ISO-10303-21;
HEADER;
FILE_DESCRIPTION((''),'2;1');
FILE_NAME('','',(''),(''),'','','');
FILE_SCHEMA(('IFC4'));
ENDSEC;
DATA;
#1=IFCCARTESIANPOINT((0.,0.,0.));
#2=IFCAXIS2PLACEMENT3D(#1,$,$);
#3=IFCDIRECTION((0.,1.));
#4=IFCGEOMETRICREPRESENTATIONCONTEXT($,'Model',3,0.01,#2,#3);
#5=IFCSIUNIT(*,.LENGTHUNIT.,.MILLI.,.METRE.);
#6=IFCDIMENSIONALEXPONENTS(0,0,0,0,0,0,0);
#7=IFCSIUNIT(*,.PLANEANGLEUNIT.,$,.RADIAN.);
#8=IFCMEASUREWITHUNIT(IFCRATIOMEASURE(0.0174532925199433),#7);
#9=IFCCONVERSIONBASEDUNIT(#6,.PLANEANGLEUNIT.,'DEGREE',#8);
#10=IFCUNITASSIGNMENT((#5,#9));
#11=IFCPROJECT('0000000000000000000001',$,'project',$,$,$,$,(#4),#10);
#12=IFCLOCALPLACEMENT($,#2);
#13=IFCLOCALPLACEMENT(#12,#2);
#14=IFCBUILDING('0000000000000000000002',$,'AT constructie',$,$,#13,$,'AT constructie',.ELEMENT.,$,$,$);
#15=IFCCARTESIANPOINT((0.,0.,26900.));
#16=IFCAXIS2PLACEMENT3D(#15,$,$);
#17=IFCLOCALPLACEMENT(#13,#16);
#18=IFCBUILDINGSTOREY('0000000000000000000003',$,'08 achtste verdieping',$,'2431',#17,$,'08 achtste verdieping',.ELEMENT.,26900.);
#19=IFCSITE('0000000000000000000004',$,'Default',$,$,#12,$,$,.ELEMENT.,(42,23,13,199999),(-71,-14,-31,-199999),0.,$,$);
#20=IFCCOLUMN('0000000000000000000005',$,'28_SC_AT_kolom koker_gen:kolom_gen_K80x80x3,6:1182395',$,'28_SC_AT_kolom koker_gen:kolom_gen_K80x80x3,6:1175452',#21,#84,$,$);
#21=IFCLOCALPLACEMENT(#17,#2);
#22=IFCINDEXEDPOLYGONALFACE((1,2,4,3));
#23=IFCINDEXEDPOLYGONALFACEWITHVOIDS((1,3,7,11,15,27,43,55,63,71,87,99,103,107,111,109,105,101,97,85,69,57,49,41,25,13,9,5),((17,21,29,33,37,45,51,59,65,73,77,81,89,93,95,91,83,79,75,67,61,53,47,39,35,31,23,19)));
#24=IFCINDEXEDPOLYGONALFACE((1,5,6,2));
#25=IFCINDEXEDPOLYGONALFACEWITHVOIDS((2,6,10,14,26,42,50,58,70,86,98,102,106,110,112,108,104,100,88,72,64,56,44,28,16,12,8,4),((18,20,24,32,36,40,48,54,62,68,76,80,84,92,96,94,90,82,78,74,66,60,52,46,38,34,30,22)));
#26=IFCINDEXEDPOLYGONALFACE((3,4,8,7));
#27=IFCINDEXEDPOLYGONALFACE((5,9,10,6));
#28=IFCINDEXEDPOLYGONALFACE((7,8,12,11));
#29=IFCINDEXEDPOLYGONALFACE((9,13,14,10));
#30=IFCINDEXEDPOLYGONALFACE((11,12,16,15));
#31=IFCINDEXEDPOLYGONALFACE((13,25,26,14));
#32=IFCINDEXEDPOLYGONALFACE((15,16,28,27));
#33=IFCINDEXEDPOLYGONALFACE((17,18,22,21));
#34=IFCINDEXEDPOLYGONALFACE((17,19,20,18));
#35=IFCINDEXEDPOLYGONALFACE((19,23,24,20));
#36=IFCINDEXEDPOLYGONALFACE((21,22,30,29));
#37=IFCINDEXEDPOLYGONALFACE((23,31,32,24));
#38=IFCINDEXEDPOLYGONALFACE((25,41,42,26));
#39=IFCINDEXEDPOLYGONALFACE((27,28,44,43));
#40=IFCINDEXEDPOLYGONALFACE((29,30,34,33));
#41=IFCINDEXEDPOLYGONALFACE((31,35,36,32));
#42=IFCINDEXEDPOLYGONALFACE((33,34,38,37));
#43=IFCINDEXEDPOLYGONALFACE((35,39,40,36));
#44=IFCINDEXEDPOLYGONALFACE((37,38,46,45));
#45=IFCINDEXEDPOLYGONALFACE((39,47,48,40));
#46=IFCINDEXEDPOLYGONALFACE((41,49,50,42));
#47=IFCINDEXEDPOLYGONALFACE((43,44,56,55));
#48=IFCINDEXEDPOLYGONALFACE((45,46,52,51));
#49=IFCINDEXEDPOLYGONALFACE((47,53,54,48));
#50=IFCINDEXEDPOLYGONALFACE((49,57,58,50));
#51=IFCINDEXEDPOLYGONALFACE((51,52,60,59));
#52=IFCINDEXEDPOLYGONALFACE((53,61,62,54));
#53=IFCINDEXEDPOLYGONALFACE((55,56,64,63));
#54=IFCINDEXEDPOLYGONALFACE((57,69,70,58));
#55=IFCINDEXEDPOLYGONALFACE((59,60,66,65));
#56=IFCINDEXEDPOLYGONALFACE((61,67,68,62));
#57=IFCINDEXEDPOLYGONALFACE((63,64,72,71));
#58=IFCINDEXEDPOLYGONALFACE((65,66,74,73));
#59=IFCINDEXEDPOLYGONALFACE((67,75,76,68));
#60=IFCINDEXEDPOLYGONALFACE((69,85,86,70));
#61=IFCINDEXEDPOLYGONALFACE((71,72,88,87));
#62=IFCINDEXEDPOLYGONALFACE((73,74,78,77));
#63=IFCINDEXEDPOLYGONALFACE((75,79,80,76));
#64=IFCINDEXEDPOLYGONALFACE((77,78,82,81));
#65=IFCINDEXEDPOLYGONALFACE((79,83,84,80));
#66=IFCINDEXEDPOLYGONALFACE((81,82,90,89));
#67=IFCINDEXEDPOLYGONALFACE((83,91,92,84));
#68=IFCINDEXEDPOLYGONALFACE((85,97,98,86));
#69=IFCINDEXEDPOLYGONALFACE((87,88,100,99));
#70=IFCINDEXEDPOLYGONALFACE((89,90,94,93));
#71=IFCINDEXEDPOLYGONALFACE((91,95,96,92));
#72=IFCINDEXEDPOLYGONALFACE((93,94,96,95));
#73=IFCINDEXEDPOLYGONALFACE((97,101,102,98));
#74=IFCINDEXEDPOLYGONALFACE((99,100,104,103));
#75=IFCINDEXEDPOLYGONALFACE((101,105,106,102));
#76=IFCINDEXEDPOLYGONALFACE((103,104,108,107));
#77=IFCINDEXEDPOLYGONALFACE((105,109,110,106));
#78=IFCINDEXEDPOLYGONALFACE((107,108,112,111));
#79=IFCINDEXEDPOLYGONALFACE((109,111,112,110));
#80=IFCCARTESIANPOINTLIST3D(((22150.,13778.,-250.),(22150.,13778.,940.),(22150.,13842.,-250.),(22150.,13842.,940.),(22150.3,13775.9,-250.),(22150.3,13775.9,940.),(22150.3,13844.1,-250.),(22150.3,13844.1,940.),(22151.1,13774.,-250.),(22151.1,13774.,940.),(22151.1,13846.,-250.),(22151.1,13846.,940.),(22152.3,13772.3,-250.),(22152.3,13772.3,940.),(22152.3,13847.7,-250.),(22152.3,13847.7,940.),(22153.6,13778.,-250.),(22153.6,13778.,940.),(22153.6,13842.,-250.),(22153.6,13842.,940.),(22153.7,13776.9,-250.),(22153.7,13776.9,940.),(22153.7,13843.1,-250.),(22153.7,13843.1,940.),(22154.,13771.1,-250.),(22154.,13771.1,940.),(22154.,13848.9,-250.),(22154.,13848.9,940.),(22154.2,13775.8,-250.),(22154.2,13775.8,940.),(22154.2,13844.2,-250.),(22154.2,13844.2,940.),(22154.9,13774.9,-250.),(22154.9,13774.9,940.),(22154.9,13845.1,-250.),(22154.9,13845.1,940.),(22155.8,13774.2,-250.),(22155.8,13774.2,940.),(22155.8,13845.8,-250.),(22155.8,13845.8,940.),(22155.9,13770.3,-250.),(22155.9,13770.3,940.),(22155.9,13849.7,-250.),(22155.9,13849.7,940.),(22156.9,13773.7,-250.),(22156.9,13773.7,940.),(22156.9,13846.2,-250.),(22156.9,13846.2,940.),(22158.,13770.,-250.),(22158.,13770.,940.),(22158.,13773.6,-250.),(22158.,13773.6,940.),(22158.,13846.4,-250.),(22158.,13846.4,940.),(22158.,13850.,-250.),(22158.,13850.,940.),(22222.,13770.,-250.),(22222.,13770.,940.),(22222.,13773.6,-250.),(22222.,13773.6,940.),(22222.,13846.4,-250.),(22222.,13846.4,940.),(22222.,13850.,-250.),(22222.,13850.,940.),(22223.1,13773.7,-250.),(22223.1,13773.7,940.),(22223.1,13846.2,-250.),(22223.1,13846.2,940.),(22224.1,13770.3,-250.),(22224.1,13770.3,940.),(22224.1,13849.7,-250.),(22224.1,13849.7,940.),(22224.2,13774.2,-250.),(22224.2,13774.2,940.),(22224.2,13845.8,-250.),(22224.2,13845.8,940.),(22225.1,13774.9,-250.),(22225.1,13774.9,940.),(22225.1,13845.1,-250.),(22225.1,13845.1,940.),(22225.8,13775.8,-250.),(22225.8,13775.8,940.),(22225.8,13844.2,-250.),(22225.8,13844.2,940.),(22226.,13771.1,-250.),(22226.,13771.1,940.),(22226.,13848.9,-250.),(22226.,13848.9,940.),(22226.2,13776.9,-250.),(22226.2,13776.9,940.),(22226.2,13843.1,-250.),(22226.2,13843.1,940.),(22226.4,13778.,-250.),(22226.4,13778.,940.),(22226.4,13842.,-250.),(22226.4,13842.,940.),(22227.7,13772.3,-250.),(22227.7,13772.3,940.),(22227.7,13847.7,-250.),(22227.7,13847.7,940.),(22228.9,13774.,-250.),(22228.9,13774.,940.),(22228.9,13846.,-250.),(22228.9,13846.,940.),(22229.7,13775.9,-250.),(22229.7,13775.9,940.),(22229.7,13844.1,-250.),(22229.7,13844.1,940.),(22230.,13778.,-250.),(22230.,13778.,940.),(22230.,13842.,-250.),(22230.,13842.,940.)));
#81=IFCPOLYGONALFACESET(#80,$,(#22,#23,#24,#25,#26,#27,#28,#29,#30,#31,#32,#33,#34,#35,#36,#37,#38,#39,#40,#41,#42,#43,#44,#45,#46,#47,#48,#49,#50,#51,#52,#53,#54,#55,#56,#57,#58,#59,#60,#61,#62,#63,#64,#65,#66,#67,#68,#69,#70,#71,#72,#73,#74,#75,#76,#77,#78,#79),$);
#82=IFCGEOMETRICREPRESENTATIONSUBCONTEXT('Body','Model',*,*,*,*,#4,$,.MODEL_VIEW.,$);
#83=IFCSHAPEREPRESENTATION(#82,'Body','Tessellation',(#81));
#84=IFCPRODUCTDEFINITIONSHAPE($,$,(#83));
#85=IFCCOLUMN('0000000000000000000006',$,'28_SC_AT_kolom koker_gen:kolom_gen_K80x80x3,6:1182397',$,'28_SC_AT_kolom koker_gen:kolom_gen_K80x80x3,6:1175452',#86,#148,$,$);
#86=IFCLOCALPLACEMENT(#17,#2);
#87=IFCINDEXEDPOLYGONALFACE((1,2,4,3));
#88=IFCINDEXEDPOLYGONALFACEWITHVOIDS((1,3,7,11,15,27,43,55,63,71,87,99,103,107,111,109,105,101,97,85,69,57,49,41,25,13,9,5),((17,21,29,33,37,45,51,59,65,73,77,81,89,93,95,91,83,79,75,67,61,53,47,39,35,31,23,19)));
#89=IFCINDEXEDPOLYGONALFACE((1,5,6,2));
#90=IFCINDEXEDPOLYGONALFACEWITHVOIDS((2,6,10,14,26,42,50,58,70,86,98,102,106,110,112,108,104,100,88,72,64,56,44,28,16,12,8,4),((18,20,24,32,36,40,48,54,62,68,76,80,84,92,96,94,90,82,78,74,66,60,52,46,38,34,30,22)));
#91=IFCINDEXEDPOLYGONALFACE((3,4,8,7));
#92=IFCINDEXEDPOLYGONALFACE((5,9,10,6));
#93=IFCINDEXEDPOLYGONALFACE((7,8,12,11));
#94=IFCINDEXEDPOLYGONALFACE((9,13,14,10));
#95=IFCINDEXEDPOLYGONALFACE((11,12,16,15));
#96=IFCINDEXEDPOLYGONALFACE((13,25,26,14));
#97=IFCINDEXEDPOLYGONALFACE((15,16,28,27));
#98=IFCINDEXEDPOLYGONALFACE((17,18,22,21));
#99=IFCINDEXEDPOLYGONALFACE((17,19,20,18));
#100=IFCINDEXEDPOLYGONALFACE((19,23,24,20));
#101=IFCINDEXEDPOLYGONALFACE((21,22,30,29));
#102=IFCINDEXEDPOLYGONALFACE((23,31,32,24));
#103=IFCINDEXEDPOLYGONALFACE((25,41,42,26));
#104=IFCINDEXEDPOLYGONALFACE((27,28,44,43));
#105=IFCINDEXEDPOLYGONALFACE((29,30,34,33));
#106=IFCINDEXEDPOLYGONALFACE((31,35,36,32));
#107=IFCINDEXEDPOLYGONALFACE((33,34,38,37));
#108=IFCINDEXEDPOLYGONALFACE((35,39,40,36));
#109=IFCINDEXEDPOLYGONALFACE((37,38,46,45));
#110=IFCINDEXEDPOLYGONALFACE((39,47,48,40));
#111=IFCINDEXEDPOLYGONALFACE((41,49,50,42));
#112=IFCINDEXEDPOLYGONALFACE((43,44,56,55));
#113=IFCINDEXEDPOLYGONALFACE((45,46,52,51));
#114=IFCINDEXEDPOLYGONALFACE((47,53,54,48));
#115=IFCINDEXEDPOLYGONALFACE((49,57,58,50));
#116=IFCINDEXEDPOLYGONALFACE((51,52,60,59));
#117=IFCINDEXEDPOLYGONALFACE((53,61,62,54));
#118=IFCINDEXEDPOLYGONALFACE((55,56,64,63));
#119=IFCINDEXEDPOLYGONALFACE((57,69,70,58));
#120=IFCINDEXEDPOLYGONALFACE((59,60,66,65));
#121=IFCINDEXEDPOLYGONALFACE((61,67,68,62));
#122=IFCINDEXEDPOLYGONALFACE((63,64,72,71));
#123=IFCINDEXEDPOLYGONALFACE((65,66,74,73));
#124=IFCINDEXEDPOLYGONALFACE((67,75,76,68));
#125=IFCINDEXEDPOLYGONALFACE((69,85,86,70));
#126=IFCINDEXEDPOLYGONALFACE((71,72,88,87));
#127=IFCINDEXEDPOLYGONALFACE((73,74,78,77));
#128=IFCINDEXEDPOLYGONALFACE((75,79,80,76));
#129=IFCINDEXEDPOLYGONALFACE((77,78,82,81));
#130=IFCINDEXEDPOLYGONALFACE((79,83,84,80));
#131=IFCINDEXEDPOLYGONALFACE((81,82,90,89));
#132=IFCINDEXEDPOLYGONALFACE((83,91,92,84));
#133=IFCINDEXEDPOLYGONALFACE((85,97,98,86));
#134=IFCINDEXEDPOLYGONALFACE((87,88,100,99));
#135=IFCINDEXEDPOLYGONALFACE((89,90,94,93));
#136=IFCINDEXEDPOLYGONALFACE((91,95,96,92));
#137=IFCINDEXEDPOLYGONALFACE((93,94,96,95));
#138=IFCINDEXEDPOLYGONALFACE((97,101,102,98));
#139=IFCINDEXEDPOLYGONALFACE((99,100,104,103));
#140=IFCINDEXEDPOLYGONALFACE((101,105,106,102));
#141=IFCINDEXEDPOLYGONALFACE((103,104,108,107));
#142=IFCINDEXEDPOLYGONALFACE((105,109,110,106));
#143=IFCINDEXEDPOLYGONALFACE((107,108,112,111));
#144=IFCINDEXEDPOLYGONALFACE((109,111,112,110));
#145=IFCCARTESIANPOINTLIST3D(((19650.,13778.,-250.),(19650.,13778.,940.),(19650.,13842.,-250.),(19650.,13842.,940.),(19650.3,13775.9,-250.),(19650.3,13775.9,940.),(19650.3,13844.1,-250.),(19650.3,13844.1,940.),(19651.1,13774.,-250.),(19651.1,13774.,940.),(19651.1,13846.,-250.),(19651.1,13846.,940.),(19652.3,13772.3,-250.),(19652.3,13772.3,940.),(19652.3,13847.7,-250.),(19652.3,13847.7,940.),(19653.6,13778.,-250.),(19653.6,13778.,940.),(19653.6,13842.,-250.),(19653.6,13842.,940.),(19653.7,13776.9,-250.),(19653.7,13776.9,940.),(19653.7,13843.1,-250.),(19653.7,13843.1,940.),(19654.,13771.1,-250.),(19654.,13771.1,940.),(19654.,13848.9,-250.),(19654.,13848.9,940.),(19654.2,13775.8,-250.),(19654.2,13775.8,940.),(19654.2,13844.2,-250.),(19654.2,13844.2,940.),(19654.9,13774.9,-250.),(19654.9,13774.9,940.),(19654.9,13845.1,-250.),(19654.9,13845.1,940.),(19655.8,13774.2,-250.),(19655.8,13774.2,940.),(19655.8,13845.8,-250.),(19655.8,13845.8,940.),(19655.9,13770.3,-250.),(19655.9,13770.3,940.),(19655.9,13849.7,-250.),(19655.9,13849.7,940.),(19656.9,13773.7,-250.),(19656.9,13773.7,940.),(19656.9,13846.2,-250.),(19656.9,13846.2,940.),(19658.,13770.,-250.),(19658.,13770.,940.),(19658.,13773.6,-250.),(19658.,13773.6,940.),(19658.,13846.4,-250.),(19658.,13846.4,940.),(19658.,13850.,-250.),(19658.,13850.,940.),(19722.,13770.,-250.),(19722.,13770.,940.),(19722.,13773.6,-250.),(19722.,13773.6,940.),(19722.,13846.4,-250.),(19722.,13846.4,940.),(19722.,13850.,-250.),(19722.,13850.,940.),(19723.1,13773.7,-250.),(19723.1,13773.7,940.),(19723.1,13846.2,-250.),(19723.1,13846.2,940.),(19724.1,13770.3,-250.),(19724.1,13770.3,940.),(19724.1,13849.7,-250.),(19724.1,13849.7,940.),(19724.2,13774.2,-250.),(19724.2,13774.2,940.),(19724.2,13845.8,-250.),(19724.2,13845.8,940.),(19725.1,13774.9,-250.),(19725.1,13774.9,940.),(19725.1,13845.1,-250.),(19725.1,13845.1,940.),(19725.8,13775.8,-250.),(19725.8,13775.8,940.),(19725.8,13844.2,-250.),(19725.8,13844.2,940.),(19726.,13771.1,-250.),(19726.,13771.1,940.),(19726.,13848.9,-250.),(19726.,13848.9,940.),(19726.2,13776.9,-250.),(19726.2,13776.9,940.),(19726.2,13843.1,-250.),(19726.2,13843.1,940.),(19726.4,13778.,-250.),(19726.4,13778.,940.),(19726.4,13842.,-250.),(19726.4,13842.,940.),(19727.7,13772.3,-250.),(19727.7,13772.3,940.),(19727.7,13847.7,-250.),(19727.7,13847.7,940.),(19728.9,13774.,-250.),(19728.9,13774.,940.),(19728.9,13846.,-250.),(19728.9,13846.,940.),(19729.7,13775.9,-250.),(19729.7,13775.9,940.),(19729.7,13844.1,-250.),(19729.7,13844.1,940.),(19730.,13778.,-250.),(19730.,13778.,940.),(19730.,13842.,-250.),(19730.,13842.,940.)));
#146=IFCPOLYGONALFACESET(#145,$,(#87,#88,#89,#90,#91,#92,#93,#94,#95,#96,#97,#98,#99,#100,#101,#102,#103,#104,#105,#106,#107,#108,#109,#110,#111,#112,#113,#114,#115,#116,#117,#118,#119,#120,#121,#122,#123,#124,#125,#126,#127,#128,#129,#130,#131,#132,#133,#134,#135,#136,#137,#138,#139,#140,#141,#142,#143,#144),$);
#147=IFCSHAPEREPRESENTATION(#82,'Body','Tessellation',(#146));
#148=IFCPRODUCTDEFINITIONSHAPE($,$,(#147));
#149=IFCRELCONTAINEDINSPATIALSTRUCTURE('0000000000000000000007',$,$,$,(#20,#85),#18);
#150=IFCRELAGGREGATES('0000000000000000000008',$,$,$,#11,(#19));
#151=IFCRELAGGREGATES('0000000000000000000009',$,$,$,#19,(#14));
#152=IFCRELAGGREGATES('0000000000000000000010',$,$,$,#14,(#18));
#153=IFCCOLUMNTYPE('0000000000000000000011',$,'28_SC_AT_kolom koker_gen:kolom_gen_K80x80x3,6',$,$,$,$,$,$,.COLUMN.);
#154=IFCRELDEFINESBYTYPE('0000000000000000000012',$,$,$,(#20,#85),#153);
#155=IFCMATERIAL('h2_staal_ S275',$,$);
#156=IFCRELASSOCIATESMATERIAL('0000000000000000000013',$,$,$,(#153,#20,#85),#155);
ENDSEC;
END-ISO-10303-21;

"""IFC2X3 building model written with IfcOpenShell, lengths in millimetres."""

from ifc_helpers import new_model, entity, si_unit, converted_unit, direction, frame, frame_2d, origin, place, context, subcontext, project, spatial, polyline, circle_curve, parameter, trimmed, segment, composite_curve, outline, extrude, source, transform, mapped, material, type_object, type_shapes, element, save


model = new_model("IFC2X3")

# Units and contexts
model_context = context("Model", 3, precision=0.01, world=origin(), true_north=direction((0.0, 1.0)))
body_context = subcontext(model_context, "Body", "Model", "MODEL_VIEW")
ifc_project = project(units=[si_unit("LENGTHUNIT", "METRE", prefix="MILLI"), converted_unit("PLANEANGLEUNIT", "DEGREE", entity("IfcRatioMeasure", 0.0174532925199433), si_unit("PLANEANGLEUNIT", "RADIAN"), dimensions=[0, 0, 0, 0, 0, 0, 0])], contexts=[model_context])

# Site, building, storey
site_placement = place(None, origin())
site = spatial("IfcSite", under=ifc_project, at=site_placement, Name="Default", CompositionType="ELEMENT", RefLatitude=(42, 23, 13, 199999), RefLongitude=(-71, -14, -31, -199999), RefElevation=0.0)
building_placement = place(site_placement, origin())
building = spatial("IfcBuilding", under=site, at=building_placement, Name="AT constructie", LongName="AT constructie", CompositionType="ELEMENT")
storey_placement = place(building_placement, frame((0.0, 0.0, 26900.0)))
storey = spatial("IfcBuildingStorey", under=building, at=storey_placement, Name="08 achtste verdieping", ObjectType="2431", LongName="08 achtste verdieping", CompositionType="ELEMENT", Elevation=26900.0)

# Columns
ifc_material_1 = material(Name="h2_staal_ S275")
column_type_1 = type_object("IfcColumnType", Name="28_SC_AT_kolom koker_gen:kolom_gen_K80x80x3,6", PredefinedType="COLUMN", material=ifc_material_1)
shared_shape_1 = source(origin(), body_context, "Body", "SweptSolid", [
    extrude(outline(composite_curve([segment(trimmed(circle_curve(frame_2d((32.0, 32.0), x_axis=(1.0, 0.0)), 8.0), [parameter(360.0)], [parameter(90.0)], True, "PARAMETER"), True, "CONTINUOUS"), segment(polyline([(32.0, 40.0), (-32.0, 40.0)]), True, "CONTINUOUS"), segment(trimmed(circle_curve(frame_2d((-32.0, 32.0), x_axis=(1.0, 0.0)), 8.0), [parameter(90.0)], [parameter(180.0)], True, "PARAMETER"), True, "CONTINUOUS"), segment(polyline([(-40.0, 32.0), (-40.0, -32.0)]), True, "CONTINUOUS"), segment(trimmed(circle_curve(frame_2d((-32.0, -32.0), x_axis=(1.0, 0.0)), 8.0), [parameter(180.0)], [parameter(270.0)], True, "PARAMETER"), True, "CONTINUOUS"), segment(polyline([(-32.0, -40.0), (32.0, -40.0)]), True, "CONTINUOUS"), segment(trimmed(circle_curve(frame_2d((32.0, -32.0), x_axis=(1.0, 0.0)), 8.0), [parameter(270.0)], [parameter(0.0)], True, "PARAMETER"), True, "CONTINUOUS"), segment(polyline([(40.0, -32.0), (40.0, 32.0)]), True, "CONTINUOUS")], self_intersect=False), holes=[composite_curve([segment(polyline([(-32.0, 36.4), (32.0, 36.4)]), True, "CONTINUOUS"), segment(trimmed(circle_curve(frame_2d((32.0, 32.0), x_axis=(1.0, 0.0)), 4.4), [parameter(360.0)], [parameter(90.0)], True, "PARAMETER"), False, "CONTINUOUS"), segment(polyline([(36.4, 32.0), (36.4, -32.0)]), True, "CONTINUOUS"), segment(trimmed(circle_curve(frame_2d((32.0, -32.0), x_axis=(1.0, 0.0)), 4.4), [parameter(270.0)], [parameter(360.0)], True, "PARAMETER"), False, "CONTINUOUS"), segment(polyline([(32.0, -36.4), (-32.0, -36.4)]), True, "CONTINUOUS"), segment(trimmed(circle_curve(frame_2d((-32.0, -32.0), x_axis=(1.0, 0.0)), 4.4), [parameter(180.0)], [parameter(270.0)], True, "PARAMETER"), False, "CONTINUOUS"), segment(polyline([(-36.4, -32.0), (-36.4, 32.0)]), True, "CONTINUOUS"), segment(trimmed(circle_curve(frame_2d((-32.0, 32.0), x_axis=(1.0, 0.0)), 4.4), [parameter(90.0)], [parameter(180.0)], True, "PARAMETER"), False, "CONTINUOUS")], self_intersect=False)]), frame((0.0, 0.0, 26650.0), z_axis=(0.0, 0.0, 1.0), x_axis=(-1.0, 0.0, 0.0)), (0.0, 0.0, 1.0), 1190.0),
])
type_shapes(column_type_1, [shared_shape_1])
for number, where, name in (
    (1, (22190.0, 13810.0, -26900.0), "28_SC_AT_kolom koker_gen:kolom_gen_K80x80x3,6:1182395"),
    (2, (19690.0, 13810.0, -26900.0), "28_SC_AT_kolom koker_gen:kolom_gen_K80x80x3,6:1182397"),
):
    element("IfcColumn", number, at=place(storey_placement, frame(where)), inside=storey, type_object=column_type_1, material=ifc_material_1, Name=name, ObjectType="28_SC_AT_kolom koker_gen:kolom_gen_K80x80x3,6:1175452", context=body_context, shape_type="MappedRepresentation", body=[
        mapped(shared_shape_1, transform((0.0, 0.0, 0.0), scale=1.0)),
    ])

save(model, "model.ifc")
